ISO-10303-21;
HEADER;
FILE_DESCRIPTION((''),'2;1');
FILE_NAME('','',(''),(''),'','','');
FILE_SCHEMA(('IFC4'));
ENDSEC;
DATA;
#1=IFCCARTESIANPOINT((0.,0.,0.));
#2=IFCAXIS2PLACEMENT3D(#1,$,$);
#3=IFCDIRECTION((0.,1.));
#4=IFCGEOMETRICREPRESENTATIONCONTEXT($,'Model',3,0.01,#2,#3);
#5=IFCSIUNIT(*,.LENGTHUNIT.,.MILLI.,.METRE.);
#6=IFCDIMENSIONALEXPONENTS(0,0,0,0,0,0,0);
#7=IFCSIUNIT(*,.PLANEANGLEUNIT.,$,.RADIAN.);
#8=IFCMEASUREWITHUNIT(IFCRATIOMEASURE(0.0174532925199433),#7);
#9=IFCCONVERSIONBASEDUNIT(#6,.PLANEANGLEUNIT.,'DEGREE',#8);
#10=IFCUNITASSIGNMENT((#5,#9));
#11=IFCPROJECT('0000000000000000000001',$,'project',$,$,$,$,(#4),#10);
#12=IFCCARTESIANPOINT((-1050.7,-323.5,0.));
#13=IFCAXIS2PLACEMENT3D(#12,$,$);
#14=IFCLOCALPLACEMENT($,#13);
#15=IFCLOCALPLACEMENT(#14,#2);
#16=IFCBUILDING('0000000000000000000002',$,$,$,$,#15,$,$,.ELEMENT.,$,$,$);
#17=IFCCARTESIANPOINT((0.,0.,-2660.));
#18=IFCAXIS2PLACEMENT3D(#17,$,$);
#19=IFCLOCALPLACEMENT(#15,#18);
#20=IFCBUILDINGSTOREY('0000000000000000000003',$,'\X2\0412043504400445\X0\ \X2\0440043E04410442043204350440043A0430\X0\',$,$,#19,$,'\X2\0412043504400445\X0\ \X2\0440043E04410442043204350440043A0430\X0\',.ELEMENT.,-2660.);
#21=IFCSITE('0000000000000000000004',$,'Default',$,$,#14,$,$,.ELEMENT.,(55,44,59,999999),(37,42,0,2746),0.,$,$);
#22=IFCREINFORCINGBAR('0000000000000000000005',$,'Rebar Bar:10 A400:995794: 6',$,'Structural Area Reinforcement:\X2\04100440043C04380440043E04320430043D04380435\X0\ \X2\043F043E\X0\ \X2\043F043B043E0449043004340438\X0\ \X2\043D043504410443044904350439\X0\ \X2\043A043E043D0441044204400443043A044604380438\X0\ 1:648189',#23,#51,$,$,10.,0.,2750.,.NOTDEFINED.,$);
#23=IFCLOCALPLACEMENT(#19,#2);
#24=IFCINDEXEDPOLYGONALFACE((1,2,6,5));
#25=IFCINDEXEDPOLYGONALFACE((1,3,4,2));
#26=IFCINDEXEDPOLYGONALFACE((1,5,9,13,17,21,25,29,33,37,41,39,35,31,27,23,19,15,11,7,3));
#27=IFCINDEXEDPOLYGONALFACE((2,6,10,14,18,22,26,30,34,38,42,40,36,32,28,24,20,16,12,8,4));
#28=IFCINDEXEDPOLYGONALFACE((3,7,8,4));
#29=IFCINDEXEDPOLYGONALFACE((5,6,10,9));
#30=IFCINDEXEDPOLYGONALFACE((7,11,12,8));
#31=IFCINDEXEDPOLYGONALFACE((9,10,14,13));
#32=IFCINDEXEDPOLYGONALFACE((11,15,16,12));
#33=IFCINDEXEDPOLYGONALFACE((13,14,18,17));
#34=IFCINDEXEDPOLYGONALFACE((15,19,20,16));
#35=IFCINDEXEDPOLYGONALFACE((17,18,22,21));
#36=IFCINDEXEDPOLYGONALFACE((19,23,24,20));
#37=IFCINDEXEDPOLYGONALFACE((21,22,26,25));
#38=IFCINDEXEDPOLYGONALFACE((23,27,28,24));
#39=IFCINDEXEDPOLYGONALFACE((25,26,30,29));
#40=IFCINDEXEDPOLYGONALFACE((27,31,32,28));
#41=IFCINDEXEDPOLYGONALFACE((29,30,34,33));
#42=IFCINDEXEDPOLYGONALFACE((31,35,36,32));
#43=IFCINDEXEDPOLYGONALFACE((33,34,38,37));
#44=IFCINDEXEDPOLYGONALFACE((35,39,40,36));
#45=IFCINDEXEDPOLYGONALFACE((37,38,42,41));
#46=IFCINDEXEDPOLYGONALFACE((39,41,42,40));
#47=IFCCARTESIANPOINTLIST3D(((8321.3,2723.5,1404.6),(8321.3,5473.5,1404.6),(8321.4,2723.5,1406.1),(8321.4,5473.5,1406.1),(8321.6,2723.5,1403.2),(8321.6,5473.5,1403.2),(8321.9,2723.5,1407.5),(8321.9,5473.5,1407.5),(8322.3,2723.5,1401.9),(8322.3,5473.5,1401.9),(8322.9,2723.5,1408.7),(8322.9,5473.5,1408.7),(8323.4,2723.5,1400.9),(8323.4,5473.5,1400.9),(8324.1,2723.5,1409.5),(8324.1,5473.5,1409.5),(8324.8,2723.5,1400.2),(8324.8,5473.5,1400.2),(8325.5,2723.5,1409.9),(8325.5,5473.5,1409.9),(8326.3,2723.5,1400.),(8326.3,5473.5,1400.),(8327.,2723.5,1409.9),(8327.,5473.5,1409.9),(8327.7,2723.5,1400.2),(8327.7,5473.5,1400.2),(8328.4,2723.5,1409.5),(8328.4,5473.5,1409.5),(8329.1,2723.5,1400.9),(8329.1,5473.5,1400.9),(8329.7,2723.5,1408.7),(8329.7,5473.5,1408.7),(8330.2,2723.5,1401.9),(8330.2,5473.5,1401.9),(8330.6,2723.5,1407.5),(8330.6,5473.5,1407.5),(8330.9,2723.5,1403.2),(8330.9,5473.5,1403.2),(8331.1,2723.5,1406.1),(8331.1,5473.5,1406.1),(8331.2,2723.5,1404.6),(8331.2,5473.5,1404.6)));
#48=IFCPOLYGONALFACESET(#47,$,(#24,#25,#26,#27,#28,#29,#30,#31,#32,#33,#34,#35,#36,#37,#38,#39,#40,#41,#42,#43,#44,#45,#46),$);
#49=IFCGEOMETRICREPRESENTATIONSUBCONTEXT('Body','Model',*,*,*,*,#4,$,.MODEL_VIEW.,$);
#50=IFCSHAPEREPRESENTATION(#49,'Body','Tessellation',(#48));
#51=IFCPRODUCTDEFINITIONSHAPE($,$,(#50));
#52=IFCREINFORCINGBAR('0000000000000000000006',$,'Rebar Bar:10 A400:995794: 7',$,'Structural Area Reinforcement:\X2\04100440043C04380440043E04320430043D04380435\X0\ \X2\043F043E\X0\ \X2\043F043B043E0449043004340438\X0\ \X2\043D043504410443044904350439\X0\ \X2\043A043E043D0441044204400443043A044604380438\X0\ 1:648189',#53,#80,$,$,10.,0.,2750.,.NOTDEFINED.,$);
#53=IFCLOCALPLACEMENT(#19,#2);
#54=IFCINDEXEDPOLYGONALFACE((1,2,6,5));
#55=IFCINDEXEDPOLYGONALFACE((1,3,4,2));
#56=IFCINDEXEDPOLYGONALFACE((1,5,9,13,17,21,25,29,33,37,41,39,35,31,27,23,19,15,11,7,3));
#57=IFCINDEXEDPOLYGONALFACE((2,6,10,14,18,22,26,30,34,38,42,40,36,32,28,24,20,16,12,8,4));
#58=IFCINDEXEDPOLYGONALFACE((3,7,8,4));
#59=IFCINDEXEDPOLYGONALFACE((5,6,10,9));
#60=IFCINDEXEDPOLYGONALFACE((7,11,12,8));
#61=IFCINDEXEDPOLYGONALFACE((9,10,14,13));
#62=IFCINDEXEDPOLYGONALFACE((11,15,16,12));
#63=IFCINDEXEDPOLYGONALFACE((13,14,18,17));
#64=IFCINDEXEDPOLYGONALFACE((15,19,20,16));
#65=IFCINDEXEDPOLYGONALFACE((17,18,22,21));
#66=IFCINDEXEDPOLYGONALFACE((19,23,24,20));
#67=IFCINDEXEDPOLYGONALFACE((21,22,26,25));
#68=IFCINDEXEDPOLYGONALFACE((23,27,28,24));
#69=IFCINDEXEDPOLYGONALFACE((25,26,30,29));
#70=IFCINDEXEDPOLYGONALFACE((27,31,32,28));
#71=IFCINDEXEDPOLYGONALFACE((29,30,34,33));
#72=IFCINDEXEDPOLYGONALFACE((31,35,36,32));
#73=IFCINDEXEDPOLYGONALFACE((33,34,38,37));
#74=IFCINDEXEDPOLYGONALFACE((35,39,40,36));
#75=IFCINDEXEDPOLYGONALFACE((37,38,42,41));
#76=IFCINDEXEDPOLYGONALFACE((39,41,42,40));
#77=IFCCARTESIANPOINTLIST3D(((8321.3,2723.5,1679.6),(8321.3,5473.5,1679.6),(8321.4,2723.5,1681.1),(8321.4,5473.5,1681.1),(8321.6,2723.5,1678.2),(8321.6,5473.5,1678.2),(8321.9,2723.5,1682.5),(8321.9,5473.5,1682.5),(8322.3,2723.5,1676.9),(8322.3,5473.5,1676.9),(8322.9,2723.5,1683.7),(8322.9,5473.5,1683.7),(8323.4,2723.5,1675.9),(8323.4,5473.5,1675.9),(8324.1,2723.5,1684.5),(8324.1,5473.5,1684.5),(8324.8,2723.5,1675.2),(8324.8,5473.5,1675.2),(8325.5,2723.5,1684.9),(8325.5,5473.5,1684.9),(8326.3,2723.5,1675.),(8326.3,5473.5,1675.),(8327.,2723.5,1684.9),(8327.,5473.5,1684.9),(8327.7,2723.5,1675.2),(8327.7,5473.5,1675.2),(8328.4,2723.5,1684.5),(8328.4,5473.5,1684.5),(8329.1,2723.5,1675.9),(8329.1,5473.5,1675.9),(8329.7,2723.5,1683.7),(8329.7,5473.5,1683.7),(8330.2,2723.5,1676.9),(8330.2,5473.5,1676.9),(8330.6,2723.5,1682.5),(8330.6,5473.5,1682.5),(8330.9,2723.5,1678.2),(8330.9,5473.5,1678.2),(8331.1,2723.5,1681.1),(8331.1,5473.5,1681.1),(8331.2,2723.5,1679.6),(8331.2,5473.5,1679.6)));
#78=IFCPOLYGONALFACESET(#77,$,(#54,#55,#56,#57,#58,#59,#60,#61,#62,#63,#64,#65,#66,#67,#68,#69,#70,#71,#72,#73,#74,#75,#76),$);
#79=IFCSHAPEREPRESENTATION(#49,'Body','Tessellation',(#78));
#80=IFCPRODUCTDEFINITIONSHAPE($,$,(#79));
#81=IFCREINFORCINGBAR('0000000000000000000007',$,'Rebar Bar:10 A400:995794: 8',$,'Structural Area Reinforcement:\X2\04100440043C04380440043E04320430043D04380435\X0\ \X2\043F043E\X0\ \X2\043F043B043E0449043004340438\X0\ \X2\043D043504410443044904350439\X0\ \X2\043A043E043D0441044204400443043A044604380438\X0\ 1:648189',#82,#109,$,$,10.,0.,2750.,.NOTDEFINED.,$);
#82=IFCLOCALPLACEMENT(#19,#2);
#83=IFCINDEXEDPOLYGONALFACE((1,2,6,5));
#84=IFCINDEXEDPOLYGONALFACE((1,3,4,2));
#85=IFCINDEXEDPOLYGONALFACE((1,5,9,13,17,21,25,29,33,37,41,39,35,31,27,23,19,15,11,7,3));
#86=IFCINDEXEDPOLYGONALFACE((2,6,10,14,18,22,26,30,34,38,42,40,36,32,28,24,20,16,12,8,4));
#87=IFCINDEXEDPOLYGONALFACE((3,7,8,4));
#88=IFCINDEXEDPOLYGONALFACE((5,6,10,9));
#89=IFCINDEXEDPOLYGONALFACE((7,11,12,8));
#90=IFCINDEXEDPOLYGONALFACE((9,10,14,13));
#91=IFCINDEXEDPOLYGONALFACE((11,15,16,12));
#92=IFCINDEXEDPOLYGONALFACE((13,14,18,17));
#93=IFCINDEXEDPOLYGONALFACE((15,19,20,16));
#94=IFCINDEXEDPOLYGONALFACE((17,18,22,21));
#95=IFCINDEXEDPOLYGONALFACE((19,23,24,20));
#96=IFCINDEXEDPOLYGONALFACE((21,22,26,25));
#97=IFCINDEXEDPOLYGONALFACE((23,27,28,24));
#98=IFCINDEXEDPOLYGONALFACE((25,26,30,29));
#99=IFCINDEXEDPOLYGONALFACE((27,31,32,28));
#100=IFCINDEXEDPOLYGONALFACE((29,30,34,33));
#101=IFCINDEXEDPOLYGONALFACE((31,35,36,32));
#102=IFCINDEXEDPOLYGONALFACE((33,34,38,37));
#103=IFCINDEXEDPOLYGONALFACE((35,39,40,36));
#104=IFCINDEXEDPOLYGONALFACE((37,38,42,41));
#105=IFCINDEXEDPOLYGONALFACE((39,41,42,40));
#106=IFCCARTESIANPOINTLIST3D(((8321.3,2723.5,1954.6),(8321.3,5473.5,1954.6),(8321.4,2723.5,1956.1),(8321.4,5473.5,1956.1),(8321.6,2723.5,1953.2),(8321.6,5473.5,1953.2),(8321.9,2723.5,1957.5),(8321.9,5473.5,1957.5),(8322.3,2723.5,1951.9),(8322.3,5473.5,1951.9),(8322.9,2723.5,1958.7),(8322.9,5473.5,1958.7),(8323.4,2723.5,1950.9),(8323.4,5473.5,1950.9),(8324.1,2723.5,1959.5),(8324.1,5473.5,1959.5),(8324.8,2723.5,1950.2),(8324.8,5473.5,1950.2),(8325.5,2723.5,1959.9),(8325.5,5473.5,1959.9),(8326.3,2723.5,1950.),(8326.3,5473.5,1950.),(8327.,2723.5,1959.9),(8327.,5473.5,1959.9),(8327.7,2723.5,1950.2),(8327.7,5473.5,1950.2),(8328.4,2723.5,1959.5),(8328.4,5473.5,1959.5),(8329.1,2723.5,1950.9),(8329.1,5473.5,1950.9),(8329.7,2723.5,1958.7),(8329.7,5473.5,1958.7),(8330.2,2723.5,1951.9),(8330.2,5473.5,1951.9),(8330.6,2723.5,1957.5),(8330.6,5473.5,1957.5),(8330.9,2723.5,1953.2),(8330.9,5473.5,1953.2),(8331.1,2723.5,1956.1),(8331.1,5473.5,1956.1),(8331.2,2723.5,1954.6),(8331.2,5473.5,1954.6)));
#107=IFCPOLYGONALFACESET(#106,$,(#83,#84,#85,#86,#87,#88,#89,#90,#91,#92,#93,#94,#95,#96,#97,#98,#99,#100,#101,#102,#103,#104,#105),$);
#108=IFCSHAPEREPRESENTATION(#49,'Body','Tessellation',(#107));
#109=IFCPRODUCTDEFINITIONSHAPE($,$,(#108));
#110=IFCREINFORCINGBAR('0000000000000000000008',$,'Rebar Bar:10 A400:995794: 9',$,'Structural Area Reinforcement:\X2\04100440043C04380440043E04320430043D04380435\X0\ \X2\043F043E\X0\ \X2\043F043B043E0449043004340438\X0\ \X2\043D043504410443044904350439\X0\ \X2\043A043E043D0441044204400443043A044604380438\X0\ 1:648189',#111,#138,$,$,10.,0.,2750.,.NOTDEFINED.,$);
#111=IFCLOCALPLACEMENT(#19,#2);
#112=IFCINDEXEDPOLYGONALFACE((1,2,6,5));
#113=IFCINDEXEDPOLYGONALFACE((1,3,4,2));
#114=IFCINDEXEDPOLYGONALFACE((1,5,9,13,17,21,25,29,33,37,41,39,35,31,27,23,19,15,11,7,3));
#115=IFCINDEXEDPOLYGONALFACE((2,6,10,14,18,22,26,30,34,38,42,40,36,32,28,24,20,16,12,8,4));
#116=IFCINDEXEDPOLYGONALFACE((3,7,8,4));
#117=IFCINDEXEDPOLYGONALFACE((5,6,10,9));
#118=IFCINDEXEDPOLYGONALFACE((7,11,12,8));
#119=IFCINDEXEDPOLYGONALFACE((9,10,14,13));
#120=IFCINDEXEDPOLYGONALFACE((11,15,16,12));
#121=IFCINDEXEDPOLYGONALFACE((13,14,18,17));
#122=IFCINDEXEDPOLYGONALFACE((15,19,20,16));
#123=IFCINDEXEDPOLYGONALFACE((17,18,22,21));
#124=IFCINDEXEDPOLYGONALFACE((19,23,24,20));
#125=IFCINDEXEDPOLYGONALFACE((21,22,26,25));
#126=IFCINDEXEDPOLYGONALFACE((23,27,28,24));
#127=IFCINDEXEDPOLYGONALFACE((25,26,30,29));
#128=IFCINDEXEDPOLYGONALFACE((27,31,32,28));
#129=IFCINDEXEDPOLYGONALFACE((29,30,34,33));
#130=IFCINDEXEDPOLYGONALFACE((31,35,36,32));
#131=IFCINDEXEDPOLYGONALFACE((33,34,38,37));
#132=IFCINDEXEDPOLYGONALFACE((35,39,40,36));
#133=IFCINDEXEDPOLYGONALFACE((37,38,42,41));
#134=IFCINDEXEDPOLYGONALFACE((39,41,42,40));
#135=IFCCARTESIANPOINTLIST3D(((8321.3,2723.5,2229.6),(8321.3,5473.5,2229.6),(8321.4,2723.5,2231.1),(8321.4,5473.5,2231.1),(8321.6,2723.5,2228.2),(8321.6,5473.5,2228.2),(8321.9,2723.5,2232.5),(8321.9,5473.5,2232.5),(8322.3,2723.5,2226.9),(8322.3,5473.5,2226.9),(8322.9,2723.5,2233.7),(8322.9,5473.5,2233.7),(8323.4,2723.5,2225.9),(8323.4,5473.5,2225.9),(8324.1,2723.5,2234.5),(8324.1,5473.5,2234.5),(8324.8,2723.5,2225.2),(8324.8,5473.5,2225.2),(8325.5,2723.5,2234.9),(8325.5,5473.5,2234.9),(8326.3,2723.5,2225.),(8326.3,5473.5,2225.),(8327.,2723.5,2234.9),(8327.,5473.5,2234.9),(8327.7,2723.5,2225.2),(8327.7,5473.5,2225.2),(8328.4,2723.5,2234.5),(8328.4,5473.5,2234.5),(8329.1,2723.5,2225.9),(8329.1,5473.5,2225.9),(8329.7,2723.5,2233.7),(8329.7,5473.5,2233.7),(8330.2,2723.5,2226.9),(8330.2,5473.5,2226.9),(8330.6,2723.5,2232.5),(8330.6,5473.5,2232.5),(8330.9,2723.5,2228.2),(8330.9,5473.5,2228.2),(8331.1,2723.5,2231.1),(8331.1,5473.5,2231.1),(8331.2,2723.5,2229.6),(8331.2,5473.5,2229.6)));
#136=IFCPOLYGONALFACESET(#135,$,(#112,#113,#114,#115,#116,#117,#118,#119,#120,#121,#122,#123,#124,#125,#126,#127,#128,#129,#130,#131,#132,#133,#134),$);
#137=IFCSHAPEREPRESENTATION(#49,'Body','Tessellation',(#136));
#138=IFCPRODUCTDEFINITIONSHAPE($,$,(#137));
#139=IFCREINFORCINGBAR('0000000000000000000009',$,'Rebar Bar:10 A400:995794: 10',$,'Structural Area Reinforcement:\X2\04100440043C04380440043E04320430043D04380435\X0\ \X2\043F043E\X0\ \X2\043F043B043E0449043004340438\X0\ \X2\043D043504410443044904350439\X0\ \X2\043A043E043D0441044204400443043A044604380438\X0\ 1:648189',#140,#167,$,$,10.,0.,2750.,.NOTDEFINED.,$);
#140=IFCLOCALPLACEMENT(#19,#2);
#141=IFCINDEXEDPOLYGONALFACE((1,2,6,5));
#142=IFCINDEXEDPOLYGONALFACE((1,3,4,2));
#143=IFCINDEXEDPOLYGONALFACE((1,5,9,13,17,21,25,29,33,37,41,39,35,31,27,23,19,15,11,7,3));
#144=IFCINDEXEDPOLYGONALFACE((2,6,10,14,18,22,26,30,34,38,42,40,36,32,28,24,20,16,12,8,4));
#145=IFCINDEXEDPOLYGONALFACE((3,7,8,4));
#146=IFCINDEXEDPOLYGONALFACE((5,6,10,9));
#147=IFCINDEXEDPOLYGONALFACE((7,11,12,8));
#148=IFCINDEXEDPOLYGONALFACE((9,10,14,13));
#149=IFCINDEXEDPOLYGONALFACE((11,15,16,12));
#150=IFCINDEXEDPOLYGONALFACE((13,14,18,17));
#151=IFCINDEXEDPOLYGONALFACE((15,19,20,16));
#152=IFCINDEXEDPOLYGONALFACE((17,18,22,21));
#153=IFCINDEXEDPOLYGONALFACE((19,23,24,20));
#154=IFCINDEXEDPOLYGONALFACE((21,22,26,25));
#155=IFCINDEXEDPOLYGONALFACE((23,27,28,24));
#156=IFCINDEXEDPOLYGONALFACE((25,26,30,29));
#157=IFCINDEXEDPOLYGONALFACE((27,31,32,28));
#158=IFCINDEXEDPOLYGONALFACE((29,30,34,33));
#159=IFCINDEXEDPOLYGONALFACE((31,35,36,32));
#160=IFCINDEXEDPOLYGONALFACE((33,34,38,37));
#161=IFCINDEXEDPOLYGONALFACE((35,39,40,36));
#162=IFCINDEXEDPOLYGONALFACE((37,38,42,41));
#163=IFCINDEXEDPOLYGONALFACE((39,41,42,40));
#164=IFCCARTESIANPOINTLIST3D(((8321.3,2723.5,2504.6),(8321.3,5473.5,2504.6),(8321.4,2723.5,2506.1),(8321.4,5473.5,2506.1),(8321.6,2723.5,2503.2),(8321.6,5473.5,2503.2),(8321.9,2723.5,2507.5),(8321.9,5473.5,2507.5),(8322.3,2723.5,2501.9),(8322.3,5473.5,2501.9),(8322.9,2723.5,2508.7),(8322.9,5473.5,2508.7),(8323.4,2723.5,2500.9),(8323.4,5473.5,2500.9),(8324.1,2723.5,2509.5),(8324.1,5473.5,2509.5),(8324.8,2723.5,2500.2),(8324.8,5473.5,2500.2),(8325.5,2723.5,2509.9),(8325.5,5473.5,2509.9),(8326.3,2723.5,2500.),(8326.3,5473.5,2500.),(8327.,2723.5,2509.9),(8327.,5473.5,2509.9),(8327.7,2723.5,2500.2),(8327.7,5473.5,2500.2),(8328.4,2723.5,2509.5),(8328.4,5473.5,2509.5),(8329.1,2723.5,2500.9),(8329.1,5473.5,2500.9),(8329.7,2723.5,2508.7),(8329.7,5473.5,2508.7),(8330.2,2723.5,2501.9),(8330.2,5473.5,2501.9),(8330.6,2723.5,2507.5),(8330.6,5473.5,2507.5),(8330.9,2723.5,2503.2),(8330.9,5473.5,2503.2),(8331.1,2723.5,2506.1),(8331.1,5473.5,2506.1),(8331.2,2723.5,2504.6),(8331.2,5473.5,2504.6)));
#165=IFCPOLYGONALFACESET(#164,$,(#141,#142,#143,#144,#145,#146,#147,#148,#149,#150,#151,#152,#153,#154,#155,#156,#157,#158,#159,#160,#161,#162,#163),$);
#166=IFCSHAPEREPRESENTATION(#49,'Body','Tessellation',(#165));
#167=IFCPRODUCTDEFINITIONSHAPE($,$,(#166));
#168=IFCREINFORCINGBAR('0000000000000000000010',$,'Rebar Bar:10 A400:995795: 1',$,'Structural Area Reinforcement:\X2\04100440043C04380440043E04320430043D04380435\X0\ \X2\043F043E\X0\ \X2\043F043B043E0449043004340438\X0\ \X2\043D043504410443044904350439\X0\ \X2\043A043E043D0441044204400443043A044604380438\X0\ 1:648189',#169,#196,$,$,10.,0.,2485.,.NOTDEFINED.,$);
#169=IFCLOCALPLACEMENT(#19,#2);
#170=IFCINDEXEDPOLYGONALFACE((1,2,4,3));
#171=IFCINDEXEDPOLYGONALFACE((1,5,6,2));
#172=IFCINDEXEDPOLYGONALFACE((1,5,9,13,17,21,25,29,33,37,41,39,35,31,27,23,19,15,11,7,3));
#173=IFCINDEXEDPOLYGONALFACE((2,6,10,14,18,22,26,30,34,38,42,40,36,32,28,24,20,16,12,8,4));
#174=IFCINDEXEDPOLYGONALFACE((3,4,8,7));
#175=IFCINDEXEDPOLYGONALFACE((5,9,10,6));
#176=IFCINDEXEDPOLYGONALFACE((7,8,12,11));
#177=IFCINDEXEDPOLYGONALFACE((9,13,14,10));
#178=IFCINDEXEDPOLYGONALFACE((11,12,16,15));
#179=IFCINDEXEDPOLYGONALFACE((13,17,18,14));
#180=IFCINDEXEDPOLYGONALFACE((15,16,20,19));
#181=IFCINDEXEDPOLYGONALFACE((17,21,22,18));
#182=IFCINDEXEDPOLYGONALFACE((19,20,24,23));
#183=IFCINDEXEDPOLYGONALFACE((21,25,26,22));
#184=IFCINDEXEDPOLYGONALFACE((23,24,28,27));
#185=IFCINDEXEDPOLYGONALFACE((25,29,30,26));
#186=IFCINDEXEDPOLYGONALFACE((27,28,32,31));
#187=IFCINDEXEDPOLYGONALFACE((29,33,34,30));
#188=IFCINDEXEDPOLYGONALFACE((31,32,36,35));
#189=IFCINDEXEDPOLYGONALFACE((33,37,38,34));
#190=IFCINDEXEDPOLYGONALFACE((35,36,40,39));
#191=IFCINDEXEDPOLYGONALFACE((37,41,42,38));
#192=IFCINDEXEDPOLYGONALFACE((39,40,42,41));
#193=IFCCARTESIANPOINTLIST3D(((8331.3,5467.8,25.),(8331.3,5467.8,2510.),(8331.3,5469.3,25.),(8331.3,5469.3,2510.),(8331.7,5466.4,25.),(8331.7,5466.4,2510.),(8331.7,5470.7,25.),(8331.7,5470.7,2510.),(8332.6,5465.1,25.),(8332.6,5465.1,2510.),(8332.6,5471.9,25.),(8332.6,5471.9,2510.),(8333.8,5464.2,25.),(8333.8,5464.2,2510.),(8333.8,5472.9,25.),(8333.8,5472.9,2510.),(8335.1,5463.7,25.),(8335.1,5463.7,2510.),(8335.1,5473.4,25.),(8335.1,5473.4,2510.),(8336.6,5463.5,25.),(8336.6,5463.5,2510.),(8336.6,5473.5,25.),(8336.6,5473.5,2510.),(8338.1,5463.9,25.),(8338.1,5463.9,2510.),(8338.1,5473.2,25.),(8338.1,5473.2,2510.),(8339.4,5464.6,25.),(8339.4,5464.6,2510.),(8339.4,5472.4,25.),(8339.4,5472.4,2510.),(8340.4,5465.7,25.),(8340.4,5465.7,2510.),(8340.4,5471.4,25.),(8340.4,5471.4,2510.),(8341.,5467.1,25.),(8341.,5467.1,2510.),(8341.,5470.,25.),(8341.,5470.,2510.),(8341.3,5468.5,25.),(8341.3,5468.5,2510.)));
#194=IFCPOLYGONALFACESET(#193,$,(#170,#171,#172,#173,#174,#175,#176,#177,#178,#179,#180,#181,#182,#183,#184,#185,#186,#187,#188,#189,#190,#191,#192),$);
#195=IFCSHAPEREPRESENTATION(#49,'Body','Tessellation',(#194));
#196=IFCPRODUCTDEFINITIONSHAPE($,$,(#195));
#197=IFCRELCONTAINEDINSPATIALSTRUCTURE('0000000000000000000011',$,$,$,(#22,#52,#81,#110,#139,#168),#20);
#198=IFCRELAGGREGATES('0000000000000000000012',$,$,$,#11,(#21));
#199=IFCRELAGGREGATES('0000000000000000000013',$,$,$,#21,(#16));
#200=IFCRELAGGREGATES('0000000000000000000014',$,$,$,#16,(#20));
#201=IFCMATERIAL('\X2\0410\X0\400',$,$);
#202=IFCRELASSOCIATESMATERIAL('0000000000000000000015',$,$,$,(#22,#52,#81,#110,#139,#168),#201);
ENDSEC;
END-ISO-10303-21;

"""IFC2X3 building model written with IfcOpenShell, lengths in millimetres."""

from ifc_helpers import new_model, entity, si_unit, converted_unit, direction, frame, origin, place, context, subcontext, project, spatial, material, element, save


model = new_model("IFC2X3")

# Units and contexts
model_context = context("Model", 3, precision=0.01, world=origin(), true_north=direction((0.0, 1.0)))
body_context = subcontext(model_context, "Body", "Model", "MODEL_VIEW")
ifc_project = project(units=[si_unit("LENGTHUNIT", "METRE", prefix="MILLI"), converted_unit("PLANEANGLEUNIT", "DEGREE", entity("IfcRatioMeasure", 0.0174532925199433), si_unit("PLANEANGLEUNIT", "RADIAN"), dimensions=[0, 0, 0, 0, 0, 0, 0])], contexts=[model_context])

# Site, building, storey
site_placement = place(None, frame((-1050.7, -323.5, 0.0)))
site = spatial("IfcSite", under=ifc_project, at=site_placement, Name="Default", CompositionType="ELEMENT", RefLatitude=(55, 44, 59, 999999), RefLongitude=(37, 42, 0, 2746), RefElevation=0.0)
building_placement = place(site_placement, origin())
building = spatial("IfcBuilding", under=site, at=building_placement, CompositionType="ELEMENT")
storey_placement = place(building_placement, frame((0.0, 0.0, -2660.0)))
storey = spatial("IfcBuildingStorey", under=building, at=storey_placement, Name="Верх ростверка", LongName="Верх ростверка", CompositionType="ELEMENT", Elevation=-2660.0)

# Reinforcing bars
ifc_material = material(Name="А400")
reinforcing_bar_1_placement = place(storey_placement, origin())
element("IfcReinforcingBar", 1, at=reinforcing_bar_1_placement, inside=storey, material=ifc_material, Name="Rebar Bar:10 A400:995794: 6", ObjectType="Structural Area Reinforcement:Армирование по площади несущей конструкции 1:648189", BarLength=2750.0, BarRole="NOTDEFINED", CrossSectionArea=0.0, NominalDiameter=10.0, context=body_context, shape_type="AdvancedSweptSolid", body=[
    entity("IfcSweptDiskSolid", entity("IfcCompositeCurve", [entity("IfcCompositeCurveSegment", "CONTINUOUS", True, entity("IfcPolyline", [entity("IfcCartesianPoint", [8326.3, 5473.5, 1405.0]), entity("IfcCartesianPoint", [8326.3, 2723.5, 1405.0])]))], False), 5.0, None, 0.0, 1.0),
])
reinforcing_bar_2_placement = place(storey_placement, origin())
element("IfcReinforcingBar", 2, at=reinforcing_bar_2_placement, inside=storey, material=ifc_material, Name="Rebar Bar:10 A400:995794: 7", ObjectType="Structural Area Reinforcement:Армирование по площади несущей конструкции 1:648189", BarLength=2750.0, BarRole="NOTDEFINED", CrossSectionArea=0.0, NominalDiameter=10.0, context=body_context, shape_type="AdvancedSweptSolid", body=[
    entity("IfcSweptDiskSolid", entity("IfcCompositeCurve", [entity("IfcCompositeCurveSegment", "CONTINUOUS", True, entity("IfcPolyline", [entity("IfcCartesianPoint", [8326.3, 5473.5, 1680.0]), entity("IfcCartesianPoint", [8326.3, 2723.5, 1680.0])]))], False), 5.0, None, 0.0, 1.0),
])
reinforcing_bar_3_placement = place(storey_placement, origin())
element("IfcReinforcingBar", 3, at=reinforcing_bar_3_placement, inside=storey, material=ifc_material, Name="Rebar Bar:10 A400:995794: 8", ObjectType="Structural Area Reinforcement:Армирование по площади несущей конструкции 1:648189", BarLength=2750.0, BarRole="NOTDEFINED", CrossSectionArea=0.0, NominalDiameter=10.0, context=body_context, shape_type="AdvancedSweptSolid", body=[
    entity("IfcSweptDiskSolid", entity("IfcCompositeCurve", [entity("IfcCompositeCurveSegment", "CONTINUOUS", True, entity("IfcPolyline", [entity("IfcCartesianPoint", [8326.3, 5473.5, 1955.0]), entity("IfcCartesianPoint", [8326.3, 2723.5, 1955.0])]))], False), 5.0, None, 0.0, 1.0),
])
reinforcing_bar_4_placement = place(storey_placement, origin())
element("IfcReinforcingBar", 4, at=reinforcing_bar_4_placement, inside=storey, material=ifc_material, Name="Rebar Bar:10 A400:995794: 9", ObjectType="Structural Area Reinforcement:Армирование по площади несущей конструкции 1:648189", BarLength=2750.0, BarRole="NOTDEFINED", CrossSectionArea=0.0, NominalDiameter=10.0, context=body_context, shape_type="AdvancedSweptSolid", body=[
    entity("IfcSweptDiskSolid", entity("IfcCompositeCurve", [entity("IfcCompositeCurveSegment", "CONTINUOUS", True, entity("IfcPolyline", [entity("IfcCartesianPoint", [8326.3, 5473.5, 2230.0]), entity("IfcCartesianPoint", [8326.3, 2723.5, 2230.0])]))], False), 5.0, None, 0.0, 1.0),
])
reinforcing_bar_5_placement = place(storey_placement, origin())
element("IfcReinforcingBar", 5, at=reinforcing_bar_5_placement, inside=storey, material=ifc_material, Name="Rebar Bar:10 A400:995794: 10", ObjectType="Structural Area Reinforcement:Армирование по площади несущей конструкции 1:648189", BarLength=2750.0, BarRole="NOTDEFINED", CrossSectionArea=0.0, NominalDiameter=10.0, context=body_context, shape_type="AdvancedSweptSolid", body=[
    entity("IfcSweptDiskSolid", entity("IfcCompositeCurve", [entity("IfcCompositeCurveSegment", "CONTINUOUS", True, entity("IfcPolyline", [entity("IfcCartesianPoint", [8326.3, 5473.5, 2505.0]), entity("IfcCartesianPoint", [8326.3, 2723.5, 2505.0])]))], False), 5.0, None, 0.0, 1.0),
])
reinforcing_bar_6_placement = place(storey_placement, origin())
element("IfcReinforcingBar", 6, at=reinforcing_bar_6_placement, inside=storey, material=ifc_material, Name="Rebar Bar:10 A400:995795: 1", ObjectType="Structural Area Reinforcement:Армирование по площади несущей конструкции 1:648189", BarLength=2485.0, BarRole="NOTDEFINED", CrossSectionArea=0.0, NominalDiameter=10.0, context=body_context, shape_type="AdvancedSweptSolid", body=[
    entity("IfcSweptDiskSolid", entity("IfcCompositeCurve", [entity("IfcCompositeCurveSegment", "CONTINUOUS", True, entity("IfcPolyline", [entity("IfcCartesianPoint", [8336.3, 5468.5, 25.0]), entity("IfcCartesianPoint", [8336.3, 5468.5, 2510.0])]))], False), 5.0, None, 0.0, 1.0),
])

save(model, "model.ifc")
